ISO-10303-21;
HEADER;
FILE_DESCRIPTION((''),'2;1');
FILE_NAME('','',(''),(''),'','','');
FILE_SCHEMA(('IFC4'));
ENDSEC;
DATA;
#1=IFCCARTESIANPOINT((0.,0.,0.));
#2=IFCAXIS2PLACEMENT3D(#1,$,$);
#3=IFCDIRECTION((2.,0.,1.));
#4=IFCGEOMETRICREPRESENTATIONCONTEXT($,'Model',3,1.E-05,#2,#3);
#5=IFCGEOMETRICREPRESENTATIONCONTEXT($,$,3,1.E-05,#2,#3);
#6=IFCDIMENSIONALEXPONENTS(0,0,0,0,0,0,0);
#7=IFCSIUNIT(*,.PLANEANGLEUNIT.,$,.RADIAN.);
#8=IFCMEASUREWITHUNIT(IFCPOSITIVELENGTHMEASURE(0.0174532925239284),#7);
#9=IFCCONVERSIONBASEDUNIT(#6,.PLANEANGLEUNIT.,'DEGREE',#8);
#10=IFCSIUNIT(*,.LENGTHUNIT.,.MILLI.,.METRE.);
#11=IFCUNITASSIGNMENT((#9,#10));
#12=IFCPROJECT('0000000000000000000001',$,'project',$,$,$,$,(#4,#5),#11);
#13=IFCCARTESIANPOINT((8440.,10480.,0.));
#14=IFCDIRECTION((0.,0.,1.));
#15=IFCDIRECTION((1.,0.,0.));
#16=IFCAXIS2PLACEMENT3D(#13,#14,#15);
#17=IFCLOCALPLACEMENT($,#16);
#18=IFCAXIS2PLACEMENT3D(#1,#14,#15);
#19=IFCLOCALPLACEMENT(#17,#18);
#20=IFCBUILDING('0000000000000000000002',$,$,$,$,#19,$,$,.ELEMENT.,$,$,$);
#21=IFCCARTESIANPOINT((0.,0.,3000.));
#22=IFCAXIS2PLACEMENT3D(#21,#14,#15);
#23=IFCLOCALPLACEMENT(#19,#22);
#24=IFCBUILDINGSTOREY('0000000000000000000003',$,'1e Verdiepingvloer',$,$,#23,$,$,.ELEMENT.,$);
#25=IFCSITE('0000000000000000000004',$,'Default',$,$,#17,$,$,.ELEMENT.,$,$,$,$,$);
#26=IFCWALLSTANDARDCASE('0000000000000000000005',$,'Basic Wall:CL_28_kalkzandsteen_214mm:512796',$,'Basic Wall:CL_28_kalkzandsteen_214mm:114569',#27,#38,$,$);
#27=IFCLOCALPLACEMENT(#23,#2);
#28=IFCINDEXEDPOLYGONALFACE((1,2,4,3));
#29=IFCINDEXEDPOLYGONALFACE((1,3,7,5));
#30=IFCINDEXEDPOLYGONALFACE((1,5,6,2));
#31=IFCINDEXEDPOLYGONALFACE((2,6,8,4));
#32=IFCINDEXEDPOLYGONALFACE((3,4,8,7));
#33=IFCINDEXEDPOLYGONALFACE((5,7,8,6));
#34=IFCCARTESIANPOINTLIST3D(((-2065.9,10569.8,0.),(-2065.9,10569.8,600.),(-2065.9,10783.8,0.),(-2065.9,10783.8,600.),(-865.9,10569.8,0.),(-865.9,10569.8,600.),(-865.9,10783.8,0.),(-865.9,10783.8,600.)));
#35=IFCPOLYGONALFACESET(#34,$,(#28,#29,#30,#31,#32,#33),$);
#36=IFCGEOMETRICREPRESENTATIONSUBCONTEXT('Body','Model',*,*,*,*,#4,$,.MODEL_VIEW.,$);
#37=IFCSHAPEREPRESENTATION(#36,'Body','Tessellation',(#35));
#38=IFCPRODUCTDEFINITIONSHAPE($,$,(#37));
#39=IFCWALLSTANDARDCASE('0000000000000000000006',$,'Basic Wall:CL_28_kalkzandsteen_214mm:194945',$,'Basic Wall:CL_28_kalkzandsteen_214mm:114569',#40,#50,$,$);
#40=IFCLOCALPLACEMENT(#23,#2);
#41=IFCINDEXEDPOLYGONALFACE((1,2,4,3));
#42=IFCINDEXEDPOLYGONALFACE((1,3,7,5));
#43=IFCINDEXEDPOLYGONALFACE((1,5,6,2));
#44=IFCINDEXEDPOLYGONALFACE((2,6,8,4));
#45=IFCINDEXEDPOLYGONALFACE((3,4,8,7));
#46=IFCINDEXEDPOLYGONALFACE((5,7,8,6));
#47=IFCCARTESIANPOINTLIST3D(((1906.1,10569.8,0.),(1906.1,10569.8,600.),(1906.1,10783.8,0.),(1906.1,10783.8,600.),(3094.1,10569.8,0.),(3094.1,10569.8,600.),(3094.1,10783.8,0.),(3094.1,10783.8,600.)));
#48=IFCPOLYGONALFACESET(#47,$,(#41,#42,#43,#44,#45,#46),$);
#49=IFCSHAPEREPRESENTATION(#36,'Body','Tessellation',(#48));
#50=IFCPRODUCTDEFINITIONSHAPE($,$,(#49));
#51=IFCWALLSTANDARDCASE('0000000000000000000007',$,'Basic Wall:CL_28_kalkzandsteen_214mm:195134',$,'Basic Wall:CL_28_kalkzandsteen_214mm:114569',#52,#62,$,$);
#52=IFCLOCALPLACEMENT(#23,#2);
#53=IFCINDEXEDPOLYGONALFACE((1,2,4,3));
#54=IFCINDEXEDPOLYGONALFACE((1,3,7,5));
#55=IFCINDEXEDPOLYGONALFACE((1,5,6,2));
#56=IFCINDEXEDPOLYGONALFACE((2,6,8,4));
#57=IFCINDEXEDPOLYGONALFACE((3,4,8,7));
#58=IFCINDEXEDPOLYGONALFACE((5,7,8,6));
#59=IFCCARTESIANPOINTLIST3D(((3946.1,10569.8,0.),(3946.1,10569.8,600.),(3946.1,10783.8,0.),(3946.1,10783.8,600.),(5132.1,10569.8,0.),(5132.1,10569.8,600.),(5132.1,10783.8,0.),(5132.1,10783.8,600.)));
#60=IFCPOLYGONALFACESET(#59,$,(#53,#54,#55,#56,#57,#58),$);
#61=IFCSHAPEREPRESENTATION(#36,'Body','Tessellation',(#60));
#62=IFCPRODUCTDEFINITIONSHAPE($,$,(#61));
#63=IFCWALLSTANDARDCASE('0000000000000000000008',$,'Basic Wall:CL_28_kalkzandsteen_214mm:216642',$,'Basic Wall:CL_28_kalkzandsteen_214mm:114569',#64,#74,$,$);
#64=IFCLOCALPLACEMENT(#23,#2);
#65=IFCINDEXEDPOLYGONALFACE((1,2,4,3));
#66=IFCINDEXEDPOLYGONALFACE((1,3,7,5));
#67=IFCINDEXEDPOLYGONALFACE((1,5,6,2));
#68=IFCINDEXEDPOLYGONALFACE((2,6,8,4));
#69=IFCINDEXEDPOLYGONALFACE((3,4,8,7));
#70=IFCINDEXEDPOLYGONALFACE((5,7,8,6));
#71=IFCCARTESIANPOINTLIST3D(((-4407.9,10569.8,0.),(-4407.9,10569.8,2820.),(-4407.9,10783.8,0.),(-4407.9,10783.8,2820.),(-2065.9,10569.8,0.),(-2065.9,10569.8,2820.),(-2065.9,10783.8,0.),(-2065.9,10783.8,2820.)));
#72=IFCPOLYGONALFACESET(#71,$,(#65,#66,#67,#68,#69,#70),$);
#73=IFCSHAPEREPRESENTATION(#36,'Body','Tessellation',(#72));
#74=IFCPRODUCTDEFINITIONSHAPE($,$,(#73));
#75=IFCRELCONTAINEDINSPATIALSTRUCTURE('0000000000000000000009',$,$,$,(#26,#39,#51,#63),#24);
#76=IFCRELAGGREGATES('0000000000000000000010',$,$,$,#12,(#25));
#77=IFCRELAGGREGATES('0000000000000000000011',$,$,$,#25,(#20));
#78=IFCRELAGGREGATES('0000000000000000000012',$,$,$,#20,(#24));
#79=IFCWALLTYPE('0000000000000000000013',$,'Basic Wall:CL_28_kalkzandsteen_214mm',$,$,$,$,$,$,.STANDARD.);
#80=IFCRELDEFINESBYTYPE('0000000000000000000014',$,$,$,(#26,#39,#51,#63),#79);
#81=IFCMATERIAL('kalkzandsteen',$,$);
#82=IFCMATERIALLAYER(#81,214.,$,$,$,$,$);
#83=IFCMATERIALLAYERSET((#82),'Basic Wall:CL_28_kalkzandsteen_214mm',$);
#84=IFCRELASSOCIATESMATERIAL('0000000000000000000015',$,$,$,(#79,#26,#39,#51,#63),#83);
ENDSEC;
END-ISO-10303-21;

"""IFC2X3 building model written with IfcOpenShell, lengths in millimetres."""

from ifc_helpers import new_model, entity, si_unit, converted_unit, direction, frame, frame_2d, origin, origin_with_axes, place, context, subcontext, project, spatial, rectangle, extrude, source, transform, mapped, material, layer, layer_set, layer_usage, type_object, element, save


model = new_model("IFC2X3")

# Units and contexts
model_context = context("Model", 3, precision=1e-05, world=origin(), true_north=direction((2.0, 0.0, 1.0)))
context_of_model = context(None, 3, precision=1e-05, world=origin(), true_north=direction((2.0, 0.0, 1.0)))
body_context = subcontext(model_context, "Body", "Model", "MODEL_VIEW")
ifc_project = project(units=[converted_unit("PLANEANGLEUNIT", "DEGREE", entity("IfcPositiveLengthMeasure", 0.0174532925239284), si_unit("PLANEANGLEUNIT", "RADIAN"), dimensions=[0, 0, 0, 0, 0, 0, 0]), si_unit("LENGTHUNIT", "METRE", prefix="MILLI")], contexts=[model_context, context_of_model])

# Site, building, storey
site_placement = place(None, frame((8440.0, 10480.0, 0.0), z_axis=(0.0, 0.0, 1.0), x_axis=(1.0, 0.0, 0.0)))
site = spatial("IfcSite", under=ifc_project, at=site_placement, Name="Default", CompositionType="ELEMENT")
building_placement = place(site_placement, origin_with_axes())
building = spatial("IfcBuilding", under=site, at=building_placement, CompositionType="ELEMENT")
storey_placement = place(building_placement, frame((0.0, 0.0, 3000.0), z_axis=(0.0, 0.0, 1.0), x_axis=(1.0, 0.0, 0.0)))
storey = spatial("IfcBuildingStorey", under=building, at=storey_placement, Name="1e Verdiepingvloer", CompositionType="ELEMENT")

# Walls
ifc_material_1 = material(Name="kalkzandsteen")
ifc_layer = layer(ifc_material_1, 214.0)
ifc_layer_set = layer_set([ifc_layer], Name="Basic Wall:CL_28_kalkzandsteen_214mm")
ifc_layer_usage_1 = layer_usage(ifc_layer_set, "AXIS2", "NEGATIVE", 107.0)
wall_type = type_object("IfcWallType", Name="Basic Wall:CL_28_kalkzandsteen_214mm", PredefinedType="STANDARD", material=ifc_layer_set)
shared_shape_1 = source(origin(), body_context, "Body", "SweptSolid", [
    extrude(rectangle(XDim=1200.0, YDim=214.0, at=frame_2d((600.0, 0.0), x_axis=(-1.0, 0.0))), origin(), (0.0, 0.0, 1.0), 600.0),
])
wall_1_placement = place(storey_placement, frame((-865.9, 10676.8, 0.0), z_axis=(0.0, 0.0, 1.0), x_axis=(-1.0, 0.0, 0.0)))
element("IfcWallStandardCase", 1, at=wall_1_placement, inside=storey, type_object=wall_type, material=ifc_layer_usage_1, Name="Basic Wall:CL_28_kalkzandsteen_214mm:512796", ObjectType="Basic Wall:CL_28_kalkzandsteen_214mm:114569", context=body_context, shape_type="MappedRepresentation", body=[
    mapped(shared_shape_1, transform((0.0, 0.0, 0.0))),
])
ifc_layer_usage_2 = layer_usage(ifc_layer_set, "AXIS2", "NEGATIVE", 107.0)
wall_2_placement = place(storey_placement, frame((3094.1, 10676.8, 0.0), z_axis=(0.0, 0.0, 1.0), x_axis=(-1.0, 0.0, 0.0)))
element("IfcWallStandardCase", 2, at=wall_2_placement, inside=storey, type_object=wall_type, material=ifc_layer_usage_2, Name="Basic Wall:CL_28_kalkzandsteen_214mm:194945", ObjectType="Basic Wall:CL_28_kalkzandsteen_214mm:114569", context=body_context, shape_type="SweptSolid", body=[
    extrude(rectangle(XDim=1188.0, YDim=214.0, at=frame_2d((594.0, 0.0), x_axis=(-1.0, 0.0))), origin(), (0.0, 0.0, 1.0), 600.0),
])
ifc_layer_usage_3 = layer_usage(ifc_layer_set, "AXIS2", "NEGATIVE", 107.0)
wall_3_placement = place(storey_placement, frame((5132.1, 10676.8, 0.0), z_axis=(0.0, 0.0, 1.0), x_axis=(-1.0, 0.0, 0.0)))
element("IfcWallStandardCase", 3, at=wall_3_placement, inside=storey, type_object=wall_type, material=ifc_layer_usage_3, Name="Basic Wall:CL_28_kalkzandsteen_214mm:195134", ObjectType="Basic Wall:CL_28_kalkzandsteen_214mm:114569", context=body_context, shape_type="SweptSolid", body=[
    extrude(rectangle(XDim=1186.0, YDim=214.0, at=frame_2d((593.0, 0.0), x_axis=(-1.0, 0.0))), origin(), (0.0, 0.0, 1.0), 600.0),
])
ifc_layer_usage_4 = layer_usage(ifc_layer_set, "AXIS2", "NEGATIVE", 107.0)
wall_4_placement = place(storey_placement, frame((-2065.9, 10676.8, 0.0), z_axis=(0.0, 0.0, 1.0), x_axis=(-1.0, 0.0, 0.0)))
element("IfcWallStandardCase", 4, at=wall_4_placement, inside=storey, type_object=wall_type, material=ifc_layer_usage_4, Name="Basic Wall:CL_28_kalkzandsteen_214mm:216642", ObjectType="Basic Wall:CL_28_kalkzandsteen_214mm:114569", context=body_context, shape_type="SweptSolid", body=[
    extrude(rectangle(XDim=2342.0, YDim=214.0, at=frame_2d((1171.0, 0.0), x_axis=(-1.0, 0.0))), origin(), (0.0, 0.0, 1.0), 2820.0),
])

save(model, "model.ifc")
